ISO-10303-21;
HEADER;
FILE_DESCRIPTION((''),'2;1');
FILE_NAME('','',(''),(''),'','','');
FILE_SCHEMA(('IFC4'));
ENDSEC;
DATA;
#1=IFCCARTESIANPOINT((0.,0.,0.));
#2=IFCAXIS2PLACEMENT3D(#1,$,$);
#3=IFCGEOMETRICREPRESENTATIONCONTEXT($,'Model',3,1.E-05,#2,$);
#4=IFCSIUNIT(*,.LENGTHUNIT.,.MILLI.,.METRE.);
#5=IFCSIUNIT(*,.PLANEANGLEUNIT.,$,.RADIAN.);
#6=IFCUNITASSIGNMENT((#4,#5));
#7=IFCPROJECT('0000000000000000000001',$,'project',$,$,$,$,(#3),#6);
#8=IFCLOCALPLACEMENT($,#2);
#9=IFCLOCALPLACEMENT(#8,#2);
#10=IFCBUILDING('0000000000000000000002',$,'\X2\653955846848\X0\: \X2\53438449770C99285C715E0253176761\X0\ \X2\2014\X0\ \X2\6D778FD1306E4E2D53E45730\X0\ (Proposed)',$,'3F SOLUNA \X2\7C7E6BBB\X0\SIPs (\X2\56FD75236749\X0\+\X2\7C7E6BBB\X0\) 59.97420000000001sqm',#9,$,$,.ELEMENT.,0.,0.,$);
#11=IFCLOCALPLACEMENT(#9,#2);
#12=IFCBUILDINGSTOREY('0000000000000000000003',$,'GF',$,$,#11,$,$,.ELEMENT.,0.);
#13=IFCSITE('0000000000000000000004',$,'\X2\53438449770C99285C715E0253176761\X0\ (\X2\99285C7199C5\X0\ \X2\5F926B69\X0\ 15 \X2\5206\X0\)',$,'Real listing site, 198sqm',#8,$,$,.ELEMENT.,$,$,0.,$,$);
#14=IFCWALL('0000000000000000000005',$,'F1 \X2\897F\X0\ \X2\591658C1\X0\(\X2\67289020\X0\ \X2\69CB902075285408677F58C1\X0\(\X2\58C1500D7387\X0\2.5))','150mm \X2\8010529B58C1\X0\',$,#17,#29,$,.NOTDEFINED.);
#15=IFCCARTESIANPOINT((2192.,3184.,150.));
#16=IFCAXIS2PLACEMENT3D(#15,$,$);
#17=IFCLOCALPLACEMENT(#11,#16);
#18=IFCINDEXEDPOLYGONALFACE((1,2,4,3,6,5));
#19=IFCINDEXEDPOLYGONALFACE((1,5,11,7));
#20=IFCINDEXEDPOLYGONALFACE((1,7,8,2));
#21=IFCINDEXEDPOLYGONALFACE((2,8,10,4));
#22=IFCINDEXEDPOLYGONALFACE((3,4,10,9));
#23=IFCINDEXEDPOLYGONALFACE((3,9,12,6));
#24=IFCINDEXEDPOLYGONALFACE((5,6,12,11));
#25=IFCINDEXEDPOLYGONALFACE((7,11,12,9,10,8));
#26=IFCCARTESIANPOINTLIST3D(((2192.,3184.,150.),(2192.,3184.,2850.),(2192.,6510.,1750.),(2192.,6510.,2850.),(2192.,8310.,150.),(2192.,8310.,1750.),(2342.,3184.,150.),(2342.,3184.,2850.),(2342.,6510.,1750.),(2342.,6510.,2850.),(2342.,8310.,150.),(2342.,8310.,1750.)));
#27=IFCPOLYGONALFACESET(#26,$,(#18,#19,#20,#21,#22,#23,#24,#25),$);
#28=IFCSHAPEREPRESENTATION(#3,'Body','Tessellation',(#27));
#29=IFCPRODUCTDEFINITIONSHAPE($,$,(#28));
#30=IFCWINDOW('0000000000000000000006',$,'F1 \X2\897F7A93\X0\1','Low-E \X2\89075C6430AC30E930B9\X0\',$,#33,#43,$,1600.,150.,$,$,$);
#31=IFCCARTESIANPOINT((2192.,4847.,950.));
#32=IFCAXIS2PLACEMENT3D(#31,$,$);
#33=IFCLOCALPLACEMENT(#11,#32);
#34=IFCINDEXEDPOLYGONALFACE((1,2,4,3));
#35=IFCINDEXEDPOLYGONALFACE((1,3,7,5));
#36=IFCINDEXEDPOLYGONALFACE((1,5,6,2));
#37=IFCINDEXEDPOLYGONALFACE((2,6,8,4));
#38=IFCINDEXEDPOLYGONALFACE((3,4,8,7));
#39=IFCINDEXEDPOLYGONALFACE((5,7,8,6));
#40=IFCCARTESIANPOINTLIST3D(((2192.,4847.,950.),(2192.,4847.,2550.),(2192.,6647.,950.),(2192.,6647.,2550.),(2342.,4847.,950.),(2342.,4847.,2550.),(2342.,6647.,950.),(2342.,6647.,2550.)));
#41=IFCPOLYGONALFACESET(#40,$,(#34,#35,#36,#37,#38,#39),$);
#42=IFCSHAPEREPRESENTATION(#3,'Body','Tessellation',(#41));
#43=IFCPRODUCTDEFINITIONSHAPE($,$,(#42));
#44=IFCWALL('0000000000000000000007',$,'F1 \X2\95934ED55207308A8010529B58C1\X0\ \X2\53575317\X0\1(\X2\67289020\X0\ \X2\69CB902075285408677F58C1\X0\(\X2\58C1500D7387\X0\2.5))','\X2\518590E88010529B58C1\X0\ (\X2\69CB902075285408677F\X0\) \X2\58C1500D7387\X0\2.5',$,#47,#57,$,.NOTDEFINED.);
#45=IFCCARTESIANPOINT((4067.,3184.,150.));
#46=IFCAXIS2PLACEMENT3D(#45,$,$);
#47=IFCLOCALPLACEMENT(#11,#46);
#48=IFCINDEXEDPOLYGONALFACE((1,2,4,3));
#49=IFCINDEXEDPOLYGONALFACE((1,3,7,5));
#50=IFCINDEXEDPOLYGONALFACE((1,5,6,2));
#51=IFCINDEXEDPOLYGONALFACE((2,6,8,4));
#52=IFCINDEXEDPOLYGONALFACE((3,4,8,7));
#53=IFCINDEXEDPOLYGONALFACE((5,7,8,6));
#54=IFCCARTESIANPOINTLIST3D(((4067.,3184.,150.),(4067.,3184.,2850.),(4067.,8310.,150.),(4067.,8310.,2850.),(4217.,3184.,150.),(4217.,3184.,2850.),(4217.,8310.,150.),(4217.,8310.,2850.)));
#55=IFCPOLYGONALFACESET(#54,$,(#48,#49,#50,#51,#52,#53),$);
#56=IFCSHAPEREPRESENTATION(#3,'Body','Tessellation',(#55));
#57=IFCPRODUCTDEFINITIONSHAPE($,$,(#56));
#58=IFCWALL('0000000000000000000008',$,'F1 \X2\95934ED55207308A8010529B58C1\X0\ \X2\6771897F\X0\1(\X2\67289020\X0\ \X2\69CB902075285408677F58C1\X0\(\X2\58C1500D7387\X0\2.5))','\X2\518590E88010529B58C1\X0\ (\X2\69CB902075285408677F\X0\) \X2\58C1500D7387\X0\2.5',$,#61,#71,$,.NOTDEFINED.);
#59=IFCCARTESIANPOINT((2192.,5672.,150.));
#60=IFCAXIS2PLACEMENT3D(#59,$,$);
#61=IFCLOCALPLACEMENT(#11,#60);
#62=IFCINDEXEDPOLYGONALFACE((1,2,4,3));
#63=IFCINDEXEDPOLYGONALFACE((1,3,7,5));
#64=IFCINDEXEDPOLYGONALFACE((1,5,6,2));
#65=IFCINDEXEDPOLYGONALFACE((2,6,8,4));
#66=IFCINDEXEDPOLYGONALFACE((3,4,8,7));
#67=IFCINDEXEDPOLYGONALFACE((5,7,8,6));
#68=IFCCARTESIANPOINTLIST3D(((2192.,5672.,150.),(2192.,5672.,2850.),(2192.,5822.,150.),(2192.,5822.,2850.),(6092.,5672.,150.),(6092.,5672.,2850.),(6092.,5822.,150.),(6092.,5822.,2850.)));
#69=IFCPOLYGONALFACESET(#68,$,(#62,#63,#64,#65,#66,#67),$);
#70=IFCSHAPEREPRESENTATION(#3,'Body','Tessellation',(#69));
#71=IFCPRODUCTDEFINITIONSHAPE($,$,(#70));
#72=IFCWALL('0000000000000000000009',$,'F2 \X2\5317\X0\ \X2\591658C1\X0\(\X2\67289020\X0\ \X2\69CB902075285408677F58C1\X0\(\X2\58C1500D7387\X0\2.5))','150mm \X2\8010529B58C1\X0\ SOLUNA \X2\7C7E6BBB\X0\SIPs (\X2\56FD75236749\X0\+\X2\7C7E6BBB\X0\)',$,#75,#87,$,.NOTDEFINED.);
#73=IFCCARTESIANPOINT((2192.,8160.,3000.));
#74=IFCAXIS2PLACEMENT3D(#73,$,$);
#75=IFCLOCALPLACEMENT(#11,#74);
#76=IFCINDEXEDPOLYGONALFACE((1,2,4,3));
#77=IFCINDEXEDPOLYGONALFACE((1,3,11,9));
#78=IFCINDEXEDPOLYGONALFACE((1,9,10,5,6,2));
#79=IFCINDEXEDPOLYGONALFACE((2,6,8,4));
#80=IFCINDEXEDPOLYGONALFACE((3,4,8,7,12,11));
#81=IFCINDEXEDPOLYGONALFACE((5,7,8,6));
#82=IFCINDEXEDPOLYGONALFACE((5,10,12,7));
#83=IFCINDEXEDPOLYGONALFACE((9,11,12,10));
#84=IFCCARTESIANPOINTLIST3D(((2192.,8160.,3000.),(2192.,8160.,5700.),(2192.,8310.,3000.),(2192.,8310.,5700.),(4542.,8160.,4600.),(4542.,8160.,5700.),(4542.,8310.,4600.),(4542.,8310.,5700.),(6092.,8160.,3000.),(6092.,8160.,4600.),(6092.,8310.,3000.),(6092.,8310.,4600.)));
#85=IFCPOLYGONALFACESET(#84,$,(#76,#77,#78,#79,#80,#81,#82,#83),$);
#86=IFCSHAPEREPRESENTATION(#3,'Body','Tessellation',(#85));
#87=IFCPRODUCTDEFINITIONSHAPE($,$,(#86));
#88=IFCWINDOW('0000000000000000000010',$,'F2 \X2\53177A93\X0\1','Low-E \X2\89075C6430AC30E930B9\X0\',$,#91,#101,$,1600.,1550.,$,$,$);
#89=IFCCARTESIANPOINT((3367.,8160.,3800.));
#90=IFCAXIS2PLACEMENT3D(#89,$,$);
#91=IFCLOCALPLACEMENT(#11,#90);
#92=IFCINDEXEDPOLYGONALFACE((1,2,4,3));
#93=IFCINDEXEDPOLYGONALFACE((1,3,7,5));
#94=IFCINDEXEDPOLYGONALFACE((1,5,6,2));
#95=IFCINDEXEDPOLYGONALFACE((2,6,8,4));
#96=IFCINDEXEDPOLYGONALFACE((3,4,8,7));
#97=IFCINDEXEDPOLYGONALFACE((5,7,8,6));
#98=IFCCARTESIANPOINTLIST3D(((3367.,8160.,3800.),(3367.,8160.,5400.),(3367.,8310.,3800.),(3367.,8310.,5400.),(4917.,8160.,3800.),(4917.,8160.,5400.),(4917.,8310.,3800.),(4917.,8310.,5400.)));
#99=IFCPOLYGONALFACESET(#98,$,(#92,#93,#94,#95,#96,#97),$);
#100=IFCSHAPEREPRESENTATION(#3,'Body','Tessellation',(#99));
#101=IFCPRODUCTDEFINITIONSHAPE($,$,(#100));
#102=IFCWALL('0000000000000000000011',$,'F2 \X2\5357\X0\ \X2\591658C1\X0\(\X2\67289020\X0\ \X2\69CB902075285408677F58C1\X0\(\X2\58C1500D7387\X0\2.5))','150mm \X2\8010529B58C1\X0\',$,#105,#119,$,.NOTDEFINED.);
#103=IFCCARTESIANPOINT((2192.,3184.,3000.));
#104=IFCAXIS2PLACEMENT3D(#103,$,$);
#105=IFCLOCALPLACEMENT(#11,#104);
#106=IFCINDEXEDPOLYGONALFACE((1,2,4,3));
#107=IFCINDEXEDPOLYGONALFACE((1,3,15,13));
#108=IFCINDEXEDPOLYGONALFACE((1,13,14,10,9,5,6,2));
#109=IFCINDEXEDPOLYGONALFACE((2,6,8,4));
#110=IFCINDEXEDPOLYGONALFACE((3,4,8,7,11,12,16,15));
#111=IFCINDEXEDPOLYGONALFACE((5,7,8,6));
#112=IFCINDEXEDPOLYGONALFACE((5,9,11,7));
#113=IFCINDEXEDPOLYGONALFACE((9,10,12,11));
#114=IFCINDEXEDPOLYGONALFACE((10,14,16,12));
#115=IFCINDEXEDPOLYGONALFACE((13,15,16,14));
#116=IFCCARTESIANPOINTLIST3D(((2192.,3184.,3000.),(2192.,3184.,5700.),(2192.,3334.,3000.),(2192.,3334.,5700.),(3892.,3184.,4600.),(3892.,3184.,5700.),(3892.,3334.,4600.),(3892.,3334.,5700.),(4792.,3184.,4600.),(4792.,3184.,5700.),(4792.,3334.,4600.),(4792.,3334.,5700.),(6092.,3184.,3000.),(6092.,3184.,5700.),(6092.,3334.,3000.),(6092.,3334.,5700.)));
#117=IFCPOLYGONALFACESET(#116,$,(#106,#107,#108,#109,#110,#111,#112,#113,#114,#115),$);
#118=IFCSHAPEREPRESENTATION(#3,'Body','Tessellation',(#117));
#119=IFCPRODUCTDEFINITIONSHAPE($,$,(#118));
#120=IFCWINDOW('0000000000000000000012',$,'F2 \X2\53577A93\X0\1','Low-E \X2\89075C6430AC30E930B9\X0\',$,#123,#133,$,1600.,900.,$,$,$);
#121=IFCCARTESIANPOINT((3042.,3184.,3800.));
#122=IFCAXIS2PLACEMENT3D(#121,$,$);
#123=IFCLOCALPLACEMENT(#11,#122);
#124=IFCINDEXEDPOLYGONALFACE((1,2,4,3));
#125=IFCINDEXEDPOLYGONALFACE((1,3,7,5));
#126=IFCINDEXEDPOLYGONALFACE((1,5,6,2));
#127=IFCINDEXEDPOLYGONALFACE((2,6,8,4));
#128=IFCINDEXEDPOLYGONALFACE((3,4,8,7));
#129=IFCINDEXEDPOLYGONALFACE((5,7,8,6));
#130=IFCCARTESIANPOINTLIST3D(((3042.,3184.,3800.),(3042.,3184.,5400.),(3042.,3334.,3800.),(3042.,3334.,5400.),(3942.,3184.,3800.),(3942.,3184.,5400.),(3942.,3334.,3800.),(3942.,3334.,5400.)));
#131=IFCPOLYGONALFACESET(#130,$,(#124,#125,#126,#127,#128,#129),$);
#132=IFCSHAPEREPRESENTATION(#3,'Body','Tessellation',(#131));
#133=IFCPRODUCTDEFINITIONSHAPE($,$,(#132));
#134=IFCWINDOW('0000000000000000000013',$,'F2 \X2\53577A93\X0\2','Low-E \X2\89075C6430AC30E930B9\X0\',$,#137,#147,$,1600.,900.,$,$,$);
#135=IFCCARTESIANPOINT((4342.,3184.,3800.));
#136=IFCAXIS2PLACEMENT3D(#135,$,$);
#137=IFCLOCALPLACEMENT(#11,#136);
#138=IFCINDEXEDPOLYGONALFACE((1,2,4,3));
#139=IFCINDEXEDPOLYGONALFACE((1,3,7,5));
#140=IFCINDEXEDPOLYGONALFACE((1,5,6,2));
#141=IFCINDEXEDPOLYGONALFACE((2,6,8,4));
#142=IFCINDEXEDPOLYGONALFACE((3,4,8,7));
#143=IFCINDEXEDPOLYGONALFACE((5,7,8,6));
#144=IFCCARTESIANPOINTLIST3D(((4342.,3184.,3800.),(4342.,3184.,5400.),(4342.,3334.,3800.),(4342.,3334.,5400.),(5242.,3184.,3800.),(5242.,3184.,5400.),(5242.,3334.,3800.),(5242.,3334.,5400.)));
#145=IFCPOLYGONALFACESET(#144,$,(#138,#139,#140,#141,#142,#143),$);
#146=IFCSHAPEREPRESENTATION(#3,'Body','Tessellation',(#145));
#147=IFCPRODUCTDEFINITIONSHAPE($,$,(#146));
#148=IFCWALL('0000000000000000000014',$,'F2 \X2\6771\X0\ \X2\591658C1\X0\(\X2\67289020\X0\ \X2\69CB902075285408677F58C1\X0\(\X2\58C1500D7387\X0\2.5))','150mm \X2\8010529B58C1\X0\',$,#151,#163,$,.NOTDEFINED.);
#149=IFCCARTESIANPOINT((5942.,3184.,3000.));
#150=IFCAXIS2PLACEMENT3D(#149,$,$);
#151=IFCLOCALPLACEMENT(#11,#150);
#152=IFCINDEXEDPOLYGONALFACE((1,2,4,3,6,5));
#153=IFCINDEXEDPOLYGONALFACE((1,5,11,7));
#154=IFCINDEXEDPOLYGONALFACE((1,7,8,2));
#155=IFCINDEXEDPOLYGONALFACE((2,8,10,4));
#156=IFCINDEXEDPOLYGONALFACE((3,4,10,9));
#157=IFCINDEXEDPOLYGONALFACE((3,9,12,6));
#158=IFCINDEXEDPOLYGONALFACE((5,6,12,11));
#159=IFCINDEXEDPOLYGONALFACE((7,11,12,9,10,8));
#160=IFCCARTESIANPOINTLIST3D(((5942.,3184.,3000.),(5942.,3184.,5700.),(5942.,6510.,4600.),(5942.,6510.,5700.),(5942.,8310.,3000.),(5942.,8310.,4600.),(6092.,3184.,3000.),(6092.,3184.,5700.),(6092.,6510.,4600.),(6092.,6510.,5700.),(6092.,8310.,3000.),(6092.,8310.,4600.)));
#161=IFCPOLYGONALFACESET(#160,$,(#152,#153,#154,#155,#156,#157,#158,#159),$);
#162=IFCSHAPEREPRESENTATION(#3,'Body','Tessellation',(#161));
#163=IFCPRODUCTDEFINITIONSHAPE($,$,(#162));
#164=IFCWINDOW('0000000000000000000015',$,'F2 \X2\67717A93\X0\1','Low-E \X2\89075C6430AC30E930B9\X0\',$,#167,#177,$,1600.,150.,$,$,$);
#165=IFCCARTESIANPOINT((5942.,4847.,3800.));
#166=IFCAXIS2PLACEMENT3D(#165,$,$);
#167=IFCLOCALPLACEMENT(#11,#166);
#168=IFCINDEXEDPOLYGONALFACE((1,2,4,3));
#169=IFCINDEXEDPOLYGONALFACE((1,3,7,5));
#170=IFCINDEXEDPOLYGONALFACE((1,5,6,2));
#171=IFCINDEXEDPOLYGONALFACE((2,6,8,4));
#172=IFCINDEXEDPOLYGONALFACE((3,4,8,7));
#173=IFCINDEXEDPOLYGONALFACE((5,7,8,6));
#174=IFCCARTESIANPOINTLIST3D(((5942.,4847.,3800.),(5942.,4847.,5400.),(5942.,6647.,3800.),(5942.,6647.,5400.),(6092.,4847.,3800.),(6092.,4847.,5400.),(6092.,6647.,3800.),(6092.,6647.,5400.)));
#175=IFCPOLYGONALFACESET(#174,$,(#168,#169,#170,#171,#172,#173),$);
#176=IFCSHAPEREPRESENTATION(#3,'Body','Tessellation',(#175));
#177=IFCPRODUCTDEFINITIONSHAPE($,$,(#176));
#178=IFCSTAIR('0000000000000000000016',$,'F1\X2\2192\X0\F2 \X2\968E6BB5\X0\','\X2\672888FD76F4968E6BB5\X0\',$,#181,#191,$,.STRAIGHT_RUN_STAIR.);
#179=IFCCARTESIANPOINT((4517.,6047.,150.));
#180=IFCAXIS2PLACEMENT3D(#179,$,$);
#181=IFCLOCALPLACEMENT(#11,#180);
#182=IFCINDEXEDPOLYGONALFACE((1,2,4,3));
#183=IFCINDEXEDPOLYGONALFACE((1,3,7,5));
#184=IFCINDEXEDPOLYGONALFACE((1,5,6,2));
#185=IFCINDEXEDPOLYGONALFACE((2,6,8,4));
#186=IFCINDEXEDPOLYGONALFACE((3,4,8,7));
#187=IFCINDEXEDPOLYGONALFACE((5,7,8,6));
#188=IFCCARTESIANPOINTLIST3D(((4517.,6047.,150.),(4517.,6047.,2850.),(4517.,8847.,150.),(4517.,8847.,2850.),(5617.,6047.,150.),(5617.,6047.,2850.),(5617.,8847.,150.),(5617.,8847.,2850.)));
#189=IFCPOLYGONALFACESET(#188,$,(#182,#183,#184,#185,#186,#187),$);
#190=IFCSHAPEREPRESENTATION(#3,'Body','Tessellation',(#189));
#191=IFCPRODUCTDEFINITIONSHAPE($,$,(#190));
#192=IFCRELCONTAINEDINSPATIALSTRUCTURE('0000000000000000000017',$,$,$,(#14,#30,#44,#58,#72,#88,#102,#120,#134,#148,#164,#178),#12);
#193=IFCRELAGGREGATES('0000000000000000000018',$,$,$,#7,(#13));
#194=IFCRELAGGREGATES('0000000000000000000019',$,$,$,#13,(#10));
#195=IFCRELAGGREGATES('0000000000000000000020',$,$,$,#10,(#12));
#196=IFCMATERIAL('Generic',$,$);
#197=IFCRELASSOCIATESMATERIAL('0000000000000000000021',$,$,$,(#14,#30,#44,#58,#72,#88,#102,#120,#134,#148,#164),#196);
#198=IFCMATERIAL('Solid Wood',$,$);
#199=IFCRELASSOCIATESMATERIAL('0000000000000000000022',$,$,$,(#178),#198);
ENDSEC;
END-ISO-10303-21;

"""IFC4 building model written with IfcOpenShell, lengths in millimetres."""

from ifc_helpers import new_model, si_unit, frame, frame_2d, origin, place, context, project, spatial, rectangle, extrude, material, element, fill, save


model = new_model("IFC4")

# Units and contexts
model_context = context("Model", 3, precision=1e-05, world=origin())
ifc_project = project(units=[si_unit("LENGTHUNIT", "METRE", prefix="MILLI"), si_unit("PLANEANGLEUNIT", "RADIAN")], contexts=[model_context])

# Site, building, storey
site_placement = place(None, origin())
site = spatial("IfcSite", under=ifc_project, at=site_placement, Name="千葉県館山市北条 (館山駅 徒歩 15 分)", ObjectType="Real listing site, 198sqm", CompositionType="ELEMENT", RefElevation=0.0)
building_placement = place(site_placement, origin())
building = spatial("IfcBuilding", under=site, at=building_placement, Name="改善案: 千葉県館山市北条 — 海近の中古地 (Proposed)", ObjectType="3F SOLUNA 籾殻SIPs (国産杉+籾殻) 59.97420000000001sqm", CompositionType="ELEMENT", ElevationOfRefHeight=0.0, ElevationOfTerrain=0.0)
storey_placement = place(building_placement, origin())
storey = spatial("IfcBuildingStorey", under=building, at=storey_placement, Name="GF", CompositionType="ELEMENT", Elevation=0.0)

# Shared definitions
ifc_material_1 = material(Name="Generic")

# Shared definitions
ifc_material_2 = material(Name="Solid Wood")

# Wall, opening, window
wall_1_placement = place(storey_placement, frame((2192.0, 3184.0, 150.0)))
wall_1 = element("IfcWall", 1, at=wall_1_placement, inside=storey, material=ifc_material_1, Name="F1 西 外壁(木造 構造用合板壁(壁倍率2.5))", Description="150mm 耐力壁", PredefinedType="NOTDEFINED", context=model_context, shape_type="SweptSolid", body=[
    extrude(rectangle(XDim=150.0, YDim=5126.0, at=frame_2d((75.0, 2563.0))), frame((2192.0, 3184.0, 150.0)), (0.0, 0.0, 1.0), 2700.0),
])
opening_1_placement = place(storey_placement, frame((2192.0, 4847.0, 950.0)))
opening_1 = element("IfcOpeningElement", 2, at=opening_1_placement, cuts=wall_1, PredefinedType="NOTDEFINED", context=model_context, shape_type="SweptSolid", body=[
    extrude(rectangle(XDim=150.0, YDim=1800.0, at=frame_2d((75.0, 900.0))), frame((2192.0, 4847.0, 950.0)), (0.0, 0.0, 1.0), 1600.0),
])
window_1_placement = place(storey_placement, frame((2192.0, 4847.0, 950.0)))
window_1 = element("IfcWindow", 3, at=window_1_placement, inside=storey, material=ifc_material_1, Name="F1 西窓1", Description="Low-E 複層ガラス", OverallHeight=1600.0, OverallWidth=150.0, context=model_context, shape_type="SweptSolid", body=[
    extrude(rectangle(XDim=150.0, YDim=1800.0, at=frame_2d((75.0, 900.0))), frame((2192.0, 4847.0, 950.0)), (0.0, 0.0, 1.0), 1600.0),
])
fill(opening_1, window_1)

# Walls
wall_2_placement = place(storey_placement, frame((4067.0, 3184.0, 150.0)))
element("IfcWall", 4, at=wall_2_placement, inside=storey, material=ifc_material_1, Name="F1 間仕切り耐力壁 南北1(木造 構造用合板壁(壁倍率2.5))", Description="内部耐力壁 (構造用合板) 壁倍率2.5", PredefinedType="NOTDEFINED", context=model_context, shape_type="SweptSolid", body=[
    extrude(rectangle(XDim=150.0, YDim=5126.0, at=frame_2d((75.0, 2563.0))), frame((4067.0, 3184.0, 150.0)), (0.0, 0.0, 1.0), 2700.0),
])
wall_3_placement = place(storey_placement, frame((2192.0, 5672.0, 150.0)))
element("IfcWall", 5, at=wall_3_placement, inside=storey, material=ifc_material_1, Name="F1 間仕切り耐力壁 東西1(木造 構造用合板壁(壁倍率2.5))", Description="内部耐力壁 (構造用合板) 壁倍率2.5", PredefinedType="NOTDEFINED", context=model_context, shape_type="SweptSolid", body=[
    extrude(rectangle(XDim=3900.0, YDim=150.0, at=frame_2d((1950.0, 75.0))), frame((2192.0, 5672.0, 150.0)), (0.0, 0.0, 1.0), 2700.0),
])

# Wall, opening, window
wall_4_placement = place(storey_placement, frame((2192.0, 8160.0, 3000.0)))
wall_4 = element("IfcWall", 6, at=wall_4_placement, inside=storey, material=ifc_material_1, Name="F2 北 外壁(木造 構造用合板壁(壁倍率2.5))", Description="150mm 耐力壁 SOLUNA 籾殻SIPs (国産杉+籾殻)", PredefinedType="NOTDEFINED", context=model_context, shape_type="SweptSolid", body=[
    extrude(rectangle(XDim=3900.0, YDim=150.0, at=frame_2d((1950.0, 75.0))), frame((2192.0, 8160.0, 3000.0)), (0.0, 0.0, 1.0), 2700.0),
])
opening_2_placement = place(storey_placement, frame((3367.0, 8160.0, 3800.0)))
opening_2 = element("IfcOpeningElement", 7, at=opening_2_placement, cuts=wall_4, PredefinedType="NOTDEFINED", context=model_context, shape_type="SweptSolid", body=[
    extrude(rectangle(XDim=1550.0, YDim=150.0, at=frame_2d((775.0, 75.0))), frame((3367.0, 8160.0, 3800.0)), (0.0, 0.0, 1.0), 1600.0),
])
window_2_placement = place(storey_placement, frame((3367.0, 8160.0, 3800.0)))
window_2 = element("IfcWindow", 8, at=window_2_placement, inside=storey, material=ifc_material_1, Name="F2 北窓1", Description="Low-E 複層ガラス", OverallHeight=1600.0, OverallWidth=1550.0, context=model_context, shape_type="SweptSolid", body=[
    extrude(rectangle(XDim=1550.0, YDim=150.0, at=frame_2d((775.0, 75.0))), frame((3367.0, 8160.0, 3800.0)), (0.0, 0.0, 1.0), 1600.0),
])
fill(opening_2, window_2)

# Wall, openings, windows
wall_5_placement = place(storey_placement, frame((2192.0, 3184.0, 3000.0)))
wall_5 = element("IfcWall", 9, at=wall_5_placement, inside=storey, material=ifc_material_1, Name="F2 南 外壁(木造 構造用合板壁(壁倍率2.5))", Description="150mm 耐力壁", PredefinedType="NOTDEFINED", context=model_context, shape_type="SweptSolid", body=[
    extrude(rectangle(XDim=3900.0, YDim=150.0, at=frame_2d((1950.0, 75.0))), frame((2192.0, 3184.0, 3000.0)), (0.0, 0.0, 1.0), 2700.0),
])
opening_3_placement = place(storey_placement, frame((3042.0, 3184.0, 3800.0)))
opening_3 = element("IfcOpeningElement", 10, at=opening_3_placement, cuts=wall_5, PredefinedType="NOTDEFINED", context=model_context, shape_type="SweptSolid", body=[
    extrude(rectangle(XDim=900.0, YDim=150.0, at=frame_2d((450.0, 75.0))), frame((3042.0, 3184.0, 3800.0)), (0.0, 0.0, 1.0), 1600.0),
])
opening_4_placement = place(storey_placement, frame((4342.0, 3184.0, 3800.0)))
opening_4 = element("IfcOpeningElement", 11, at=opening_4_placement, cuts=wall_5, PredefinedType="NOTDEFINED", context=model_context, shape_type="SweptSolid", body=[
    extrude(rectangle(XDim=900.0, YDim=150.0, at=frame_2d((450.0, 75.0))), frame((4342.0, 3184.0, 3800.0)), (0.0, 0.0, 1.0), 1600.0),
])
window_3_placement = place(storey_placement, frame((3042.0, 3184.0, 3800.0)))
window_3 = element("IfcWindow", 12, at=window_3_placement, inside=storey, material=ifc_material_1, Name="F2 南窓1", Description="Low-E 複層ガラス", OverallHeight=1600.0, OverallWidth=900.0, context=model_context, shape_type="SweptSolid", body=[
    extrude(rectangle(XDim=900.0, YDim=150.0, at=frame_2d((450.0, 75.0))), frame((3042.0, 3184.0, 3800.0)), (0.0, 0.0, 1.0), 1600.0),
])
fill(opening_3, window_3)
window_4_placement = place(storey_placement, frame((4342.0, 3184.0, 3800.0)))
window_4 = element("IfcWindow", 13, at=window_4_placement, inside=storey, material=ifc_material_1, Name="F2 南窓2", Description="Low-E 複層ガラス", OverallHeight=1600.0, OverallWidth=900.0, context=model_context, shape_type="SweptSolid", body=[
    extrude(rectangle(XDim=900.0, YDim=150.0, at=frame_2d((450.0, 75.0))), frame((4342.0, 3184.0, 3800.0)), (0.0, 0.0, 1.0), 1600.0),
])
fill(opening_4, window_4)

# Wall, opening, window
wall_6_placement = place(storey_placement, frame((5942.0, 3184.0, 3000.0)))
wall_6 = element("IfcWall", 14, at=wall_6_placement, inside=storey, material=ifc_material_1, Name="F2 東 外壁(木造 構造用合板壁(壁倍率2.5))", Description="150mm 耐力壁", PredefinedType="NOTDEFINED", context=model_context, shape_type="SweptSolid", body=[
    extrude(rectangle(XDim=150.0, YDim=5126.0, at=frame_2d((75.0, 2563.0))), frame((5942.0, 3184.0, 3000.0)), (0.0, 0.0, 1.0), 2700.0),
])
opening_5_placement = place(storey_placement, frame((5942.0, 4847.0, 3800.0)))
opening_5 = element("IfcOpeningElement", 15, at=opening_5_placement, cuts=wall_6, PredefinedType="NOTDEFINED", context=model_context, shape_type="SweptSolid", body=[
    extrude(rectangle(XDim=150.0, YDim=1800.0, at=frame_2d((75.0, 900.0))), frame((5942.0, 4847.0, 3800.0)), (0.0, 0.0, 1.0), 1600.0),
])
window_5_placement = place(storey_placement, frame((5942.0, 4847.0, 3800.0)))
window_5 = element("IfcWindow", 16, at=window_5_placement, inside=storey, material=ifc_material_1, Name="F2 東窓1", Description="Low-E 複層ガラス", OverallHeight=1600.0, OverallWidth=150.0, context=model_context, shape_type="SweptSolid", body=[
    extrude(rectangle(XDim=150.0, YDim=1800.0, at=frame_2d((75.0, 900.0))), frame((5942.0, 4847.0, 3800.0)), (0.0, 0.0, 1.0), 1600.0),
])
fill(opening_5, window_5)

# Stair
stair_placement = place(storey_placement, frame((4517.0, 6047.0, 150.0)))
element("IfcStair", 17, at=stair_placement, inside=storey, material=ifc_material_2, Name="F1→F2 階段", Description="木製直階段", PredefinedType="STRAIGHT_RUN_STAIR", context=model_context, shape_type="SweptSolid", body=[
    extrude(rectangle(XDim=1100.0, YDim=2800.0, at=frame_2d((550.0, 1400.0))), frame((4517.0, 6047.0, 150.0)), (0.0, 0.0, 1.0), 2700.0),
])

save(model, "model.ifc")
